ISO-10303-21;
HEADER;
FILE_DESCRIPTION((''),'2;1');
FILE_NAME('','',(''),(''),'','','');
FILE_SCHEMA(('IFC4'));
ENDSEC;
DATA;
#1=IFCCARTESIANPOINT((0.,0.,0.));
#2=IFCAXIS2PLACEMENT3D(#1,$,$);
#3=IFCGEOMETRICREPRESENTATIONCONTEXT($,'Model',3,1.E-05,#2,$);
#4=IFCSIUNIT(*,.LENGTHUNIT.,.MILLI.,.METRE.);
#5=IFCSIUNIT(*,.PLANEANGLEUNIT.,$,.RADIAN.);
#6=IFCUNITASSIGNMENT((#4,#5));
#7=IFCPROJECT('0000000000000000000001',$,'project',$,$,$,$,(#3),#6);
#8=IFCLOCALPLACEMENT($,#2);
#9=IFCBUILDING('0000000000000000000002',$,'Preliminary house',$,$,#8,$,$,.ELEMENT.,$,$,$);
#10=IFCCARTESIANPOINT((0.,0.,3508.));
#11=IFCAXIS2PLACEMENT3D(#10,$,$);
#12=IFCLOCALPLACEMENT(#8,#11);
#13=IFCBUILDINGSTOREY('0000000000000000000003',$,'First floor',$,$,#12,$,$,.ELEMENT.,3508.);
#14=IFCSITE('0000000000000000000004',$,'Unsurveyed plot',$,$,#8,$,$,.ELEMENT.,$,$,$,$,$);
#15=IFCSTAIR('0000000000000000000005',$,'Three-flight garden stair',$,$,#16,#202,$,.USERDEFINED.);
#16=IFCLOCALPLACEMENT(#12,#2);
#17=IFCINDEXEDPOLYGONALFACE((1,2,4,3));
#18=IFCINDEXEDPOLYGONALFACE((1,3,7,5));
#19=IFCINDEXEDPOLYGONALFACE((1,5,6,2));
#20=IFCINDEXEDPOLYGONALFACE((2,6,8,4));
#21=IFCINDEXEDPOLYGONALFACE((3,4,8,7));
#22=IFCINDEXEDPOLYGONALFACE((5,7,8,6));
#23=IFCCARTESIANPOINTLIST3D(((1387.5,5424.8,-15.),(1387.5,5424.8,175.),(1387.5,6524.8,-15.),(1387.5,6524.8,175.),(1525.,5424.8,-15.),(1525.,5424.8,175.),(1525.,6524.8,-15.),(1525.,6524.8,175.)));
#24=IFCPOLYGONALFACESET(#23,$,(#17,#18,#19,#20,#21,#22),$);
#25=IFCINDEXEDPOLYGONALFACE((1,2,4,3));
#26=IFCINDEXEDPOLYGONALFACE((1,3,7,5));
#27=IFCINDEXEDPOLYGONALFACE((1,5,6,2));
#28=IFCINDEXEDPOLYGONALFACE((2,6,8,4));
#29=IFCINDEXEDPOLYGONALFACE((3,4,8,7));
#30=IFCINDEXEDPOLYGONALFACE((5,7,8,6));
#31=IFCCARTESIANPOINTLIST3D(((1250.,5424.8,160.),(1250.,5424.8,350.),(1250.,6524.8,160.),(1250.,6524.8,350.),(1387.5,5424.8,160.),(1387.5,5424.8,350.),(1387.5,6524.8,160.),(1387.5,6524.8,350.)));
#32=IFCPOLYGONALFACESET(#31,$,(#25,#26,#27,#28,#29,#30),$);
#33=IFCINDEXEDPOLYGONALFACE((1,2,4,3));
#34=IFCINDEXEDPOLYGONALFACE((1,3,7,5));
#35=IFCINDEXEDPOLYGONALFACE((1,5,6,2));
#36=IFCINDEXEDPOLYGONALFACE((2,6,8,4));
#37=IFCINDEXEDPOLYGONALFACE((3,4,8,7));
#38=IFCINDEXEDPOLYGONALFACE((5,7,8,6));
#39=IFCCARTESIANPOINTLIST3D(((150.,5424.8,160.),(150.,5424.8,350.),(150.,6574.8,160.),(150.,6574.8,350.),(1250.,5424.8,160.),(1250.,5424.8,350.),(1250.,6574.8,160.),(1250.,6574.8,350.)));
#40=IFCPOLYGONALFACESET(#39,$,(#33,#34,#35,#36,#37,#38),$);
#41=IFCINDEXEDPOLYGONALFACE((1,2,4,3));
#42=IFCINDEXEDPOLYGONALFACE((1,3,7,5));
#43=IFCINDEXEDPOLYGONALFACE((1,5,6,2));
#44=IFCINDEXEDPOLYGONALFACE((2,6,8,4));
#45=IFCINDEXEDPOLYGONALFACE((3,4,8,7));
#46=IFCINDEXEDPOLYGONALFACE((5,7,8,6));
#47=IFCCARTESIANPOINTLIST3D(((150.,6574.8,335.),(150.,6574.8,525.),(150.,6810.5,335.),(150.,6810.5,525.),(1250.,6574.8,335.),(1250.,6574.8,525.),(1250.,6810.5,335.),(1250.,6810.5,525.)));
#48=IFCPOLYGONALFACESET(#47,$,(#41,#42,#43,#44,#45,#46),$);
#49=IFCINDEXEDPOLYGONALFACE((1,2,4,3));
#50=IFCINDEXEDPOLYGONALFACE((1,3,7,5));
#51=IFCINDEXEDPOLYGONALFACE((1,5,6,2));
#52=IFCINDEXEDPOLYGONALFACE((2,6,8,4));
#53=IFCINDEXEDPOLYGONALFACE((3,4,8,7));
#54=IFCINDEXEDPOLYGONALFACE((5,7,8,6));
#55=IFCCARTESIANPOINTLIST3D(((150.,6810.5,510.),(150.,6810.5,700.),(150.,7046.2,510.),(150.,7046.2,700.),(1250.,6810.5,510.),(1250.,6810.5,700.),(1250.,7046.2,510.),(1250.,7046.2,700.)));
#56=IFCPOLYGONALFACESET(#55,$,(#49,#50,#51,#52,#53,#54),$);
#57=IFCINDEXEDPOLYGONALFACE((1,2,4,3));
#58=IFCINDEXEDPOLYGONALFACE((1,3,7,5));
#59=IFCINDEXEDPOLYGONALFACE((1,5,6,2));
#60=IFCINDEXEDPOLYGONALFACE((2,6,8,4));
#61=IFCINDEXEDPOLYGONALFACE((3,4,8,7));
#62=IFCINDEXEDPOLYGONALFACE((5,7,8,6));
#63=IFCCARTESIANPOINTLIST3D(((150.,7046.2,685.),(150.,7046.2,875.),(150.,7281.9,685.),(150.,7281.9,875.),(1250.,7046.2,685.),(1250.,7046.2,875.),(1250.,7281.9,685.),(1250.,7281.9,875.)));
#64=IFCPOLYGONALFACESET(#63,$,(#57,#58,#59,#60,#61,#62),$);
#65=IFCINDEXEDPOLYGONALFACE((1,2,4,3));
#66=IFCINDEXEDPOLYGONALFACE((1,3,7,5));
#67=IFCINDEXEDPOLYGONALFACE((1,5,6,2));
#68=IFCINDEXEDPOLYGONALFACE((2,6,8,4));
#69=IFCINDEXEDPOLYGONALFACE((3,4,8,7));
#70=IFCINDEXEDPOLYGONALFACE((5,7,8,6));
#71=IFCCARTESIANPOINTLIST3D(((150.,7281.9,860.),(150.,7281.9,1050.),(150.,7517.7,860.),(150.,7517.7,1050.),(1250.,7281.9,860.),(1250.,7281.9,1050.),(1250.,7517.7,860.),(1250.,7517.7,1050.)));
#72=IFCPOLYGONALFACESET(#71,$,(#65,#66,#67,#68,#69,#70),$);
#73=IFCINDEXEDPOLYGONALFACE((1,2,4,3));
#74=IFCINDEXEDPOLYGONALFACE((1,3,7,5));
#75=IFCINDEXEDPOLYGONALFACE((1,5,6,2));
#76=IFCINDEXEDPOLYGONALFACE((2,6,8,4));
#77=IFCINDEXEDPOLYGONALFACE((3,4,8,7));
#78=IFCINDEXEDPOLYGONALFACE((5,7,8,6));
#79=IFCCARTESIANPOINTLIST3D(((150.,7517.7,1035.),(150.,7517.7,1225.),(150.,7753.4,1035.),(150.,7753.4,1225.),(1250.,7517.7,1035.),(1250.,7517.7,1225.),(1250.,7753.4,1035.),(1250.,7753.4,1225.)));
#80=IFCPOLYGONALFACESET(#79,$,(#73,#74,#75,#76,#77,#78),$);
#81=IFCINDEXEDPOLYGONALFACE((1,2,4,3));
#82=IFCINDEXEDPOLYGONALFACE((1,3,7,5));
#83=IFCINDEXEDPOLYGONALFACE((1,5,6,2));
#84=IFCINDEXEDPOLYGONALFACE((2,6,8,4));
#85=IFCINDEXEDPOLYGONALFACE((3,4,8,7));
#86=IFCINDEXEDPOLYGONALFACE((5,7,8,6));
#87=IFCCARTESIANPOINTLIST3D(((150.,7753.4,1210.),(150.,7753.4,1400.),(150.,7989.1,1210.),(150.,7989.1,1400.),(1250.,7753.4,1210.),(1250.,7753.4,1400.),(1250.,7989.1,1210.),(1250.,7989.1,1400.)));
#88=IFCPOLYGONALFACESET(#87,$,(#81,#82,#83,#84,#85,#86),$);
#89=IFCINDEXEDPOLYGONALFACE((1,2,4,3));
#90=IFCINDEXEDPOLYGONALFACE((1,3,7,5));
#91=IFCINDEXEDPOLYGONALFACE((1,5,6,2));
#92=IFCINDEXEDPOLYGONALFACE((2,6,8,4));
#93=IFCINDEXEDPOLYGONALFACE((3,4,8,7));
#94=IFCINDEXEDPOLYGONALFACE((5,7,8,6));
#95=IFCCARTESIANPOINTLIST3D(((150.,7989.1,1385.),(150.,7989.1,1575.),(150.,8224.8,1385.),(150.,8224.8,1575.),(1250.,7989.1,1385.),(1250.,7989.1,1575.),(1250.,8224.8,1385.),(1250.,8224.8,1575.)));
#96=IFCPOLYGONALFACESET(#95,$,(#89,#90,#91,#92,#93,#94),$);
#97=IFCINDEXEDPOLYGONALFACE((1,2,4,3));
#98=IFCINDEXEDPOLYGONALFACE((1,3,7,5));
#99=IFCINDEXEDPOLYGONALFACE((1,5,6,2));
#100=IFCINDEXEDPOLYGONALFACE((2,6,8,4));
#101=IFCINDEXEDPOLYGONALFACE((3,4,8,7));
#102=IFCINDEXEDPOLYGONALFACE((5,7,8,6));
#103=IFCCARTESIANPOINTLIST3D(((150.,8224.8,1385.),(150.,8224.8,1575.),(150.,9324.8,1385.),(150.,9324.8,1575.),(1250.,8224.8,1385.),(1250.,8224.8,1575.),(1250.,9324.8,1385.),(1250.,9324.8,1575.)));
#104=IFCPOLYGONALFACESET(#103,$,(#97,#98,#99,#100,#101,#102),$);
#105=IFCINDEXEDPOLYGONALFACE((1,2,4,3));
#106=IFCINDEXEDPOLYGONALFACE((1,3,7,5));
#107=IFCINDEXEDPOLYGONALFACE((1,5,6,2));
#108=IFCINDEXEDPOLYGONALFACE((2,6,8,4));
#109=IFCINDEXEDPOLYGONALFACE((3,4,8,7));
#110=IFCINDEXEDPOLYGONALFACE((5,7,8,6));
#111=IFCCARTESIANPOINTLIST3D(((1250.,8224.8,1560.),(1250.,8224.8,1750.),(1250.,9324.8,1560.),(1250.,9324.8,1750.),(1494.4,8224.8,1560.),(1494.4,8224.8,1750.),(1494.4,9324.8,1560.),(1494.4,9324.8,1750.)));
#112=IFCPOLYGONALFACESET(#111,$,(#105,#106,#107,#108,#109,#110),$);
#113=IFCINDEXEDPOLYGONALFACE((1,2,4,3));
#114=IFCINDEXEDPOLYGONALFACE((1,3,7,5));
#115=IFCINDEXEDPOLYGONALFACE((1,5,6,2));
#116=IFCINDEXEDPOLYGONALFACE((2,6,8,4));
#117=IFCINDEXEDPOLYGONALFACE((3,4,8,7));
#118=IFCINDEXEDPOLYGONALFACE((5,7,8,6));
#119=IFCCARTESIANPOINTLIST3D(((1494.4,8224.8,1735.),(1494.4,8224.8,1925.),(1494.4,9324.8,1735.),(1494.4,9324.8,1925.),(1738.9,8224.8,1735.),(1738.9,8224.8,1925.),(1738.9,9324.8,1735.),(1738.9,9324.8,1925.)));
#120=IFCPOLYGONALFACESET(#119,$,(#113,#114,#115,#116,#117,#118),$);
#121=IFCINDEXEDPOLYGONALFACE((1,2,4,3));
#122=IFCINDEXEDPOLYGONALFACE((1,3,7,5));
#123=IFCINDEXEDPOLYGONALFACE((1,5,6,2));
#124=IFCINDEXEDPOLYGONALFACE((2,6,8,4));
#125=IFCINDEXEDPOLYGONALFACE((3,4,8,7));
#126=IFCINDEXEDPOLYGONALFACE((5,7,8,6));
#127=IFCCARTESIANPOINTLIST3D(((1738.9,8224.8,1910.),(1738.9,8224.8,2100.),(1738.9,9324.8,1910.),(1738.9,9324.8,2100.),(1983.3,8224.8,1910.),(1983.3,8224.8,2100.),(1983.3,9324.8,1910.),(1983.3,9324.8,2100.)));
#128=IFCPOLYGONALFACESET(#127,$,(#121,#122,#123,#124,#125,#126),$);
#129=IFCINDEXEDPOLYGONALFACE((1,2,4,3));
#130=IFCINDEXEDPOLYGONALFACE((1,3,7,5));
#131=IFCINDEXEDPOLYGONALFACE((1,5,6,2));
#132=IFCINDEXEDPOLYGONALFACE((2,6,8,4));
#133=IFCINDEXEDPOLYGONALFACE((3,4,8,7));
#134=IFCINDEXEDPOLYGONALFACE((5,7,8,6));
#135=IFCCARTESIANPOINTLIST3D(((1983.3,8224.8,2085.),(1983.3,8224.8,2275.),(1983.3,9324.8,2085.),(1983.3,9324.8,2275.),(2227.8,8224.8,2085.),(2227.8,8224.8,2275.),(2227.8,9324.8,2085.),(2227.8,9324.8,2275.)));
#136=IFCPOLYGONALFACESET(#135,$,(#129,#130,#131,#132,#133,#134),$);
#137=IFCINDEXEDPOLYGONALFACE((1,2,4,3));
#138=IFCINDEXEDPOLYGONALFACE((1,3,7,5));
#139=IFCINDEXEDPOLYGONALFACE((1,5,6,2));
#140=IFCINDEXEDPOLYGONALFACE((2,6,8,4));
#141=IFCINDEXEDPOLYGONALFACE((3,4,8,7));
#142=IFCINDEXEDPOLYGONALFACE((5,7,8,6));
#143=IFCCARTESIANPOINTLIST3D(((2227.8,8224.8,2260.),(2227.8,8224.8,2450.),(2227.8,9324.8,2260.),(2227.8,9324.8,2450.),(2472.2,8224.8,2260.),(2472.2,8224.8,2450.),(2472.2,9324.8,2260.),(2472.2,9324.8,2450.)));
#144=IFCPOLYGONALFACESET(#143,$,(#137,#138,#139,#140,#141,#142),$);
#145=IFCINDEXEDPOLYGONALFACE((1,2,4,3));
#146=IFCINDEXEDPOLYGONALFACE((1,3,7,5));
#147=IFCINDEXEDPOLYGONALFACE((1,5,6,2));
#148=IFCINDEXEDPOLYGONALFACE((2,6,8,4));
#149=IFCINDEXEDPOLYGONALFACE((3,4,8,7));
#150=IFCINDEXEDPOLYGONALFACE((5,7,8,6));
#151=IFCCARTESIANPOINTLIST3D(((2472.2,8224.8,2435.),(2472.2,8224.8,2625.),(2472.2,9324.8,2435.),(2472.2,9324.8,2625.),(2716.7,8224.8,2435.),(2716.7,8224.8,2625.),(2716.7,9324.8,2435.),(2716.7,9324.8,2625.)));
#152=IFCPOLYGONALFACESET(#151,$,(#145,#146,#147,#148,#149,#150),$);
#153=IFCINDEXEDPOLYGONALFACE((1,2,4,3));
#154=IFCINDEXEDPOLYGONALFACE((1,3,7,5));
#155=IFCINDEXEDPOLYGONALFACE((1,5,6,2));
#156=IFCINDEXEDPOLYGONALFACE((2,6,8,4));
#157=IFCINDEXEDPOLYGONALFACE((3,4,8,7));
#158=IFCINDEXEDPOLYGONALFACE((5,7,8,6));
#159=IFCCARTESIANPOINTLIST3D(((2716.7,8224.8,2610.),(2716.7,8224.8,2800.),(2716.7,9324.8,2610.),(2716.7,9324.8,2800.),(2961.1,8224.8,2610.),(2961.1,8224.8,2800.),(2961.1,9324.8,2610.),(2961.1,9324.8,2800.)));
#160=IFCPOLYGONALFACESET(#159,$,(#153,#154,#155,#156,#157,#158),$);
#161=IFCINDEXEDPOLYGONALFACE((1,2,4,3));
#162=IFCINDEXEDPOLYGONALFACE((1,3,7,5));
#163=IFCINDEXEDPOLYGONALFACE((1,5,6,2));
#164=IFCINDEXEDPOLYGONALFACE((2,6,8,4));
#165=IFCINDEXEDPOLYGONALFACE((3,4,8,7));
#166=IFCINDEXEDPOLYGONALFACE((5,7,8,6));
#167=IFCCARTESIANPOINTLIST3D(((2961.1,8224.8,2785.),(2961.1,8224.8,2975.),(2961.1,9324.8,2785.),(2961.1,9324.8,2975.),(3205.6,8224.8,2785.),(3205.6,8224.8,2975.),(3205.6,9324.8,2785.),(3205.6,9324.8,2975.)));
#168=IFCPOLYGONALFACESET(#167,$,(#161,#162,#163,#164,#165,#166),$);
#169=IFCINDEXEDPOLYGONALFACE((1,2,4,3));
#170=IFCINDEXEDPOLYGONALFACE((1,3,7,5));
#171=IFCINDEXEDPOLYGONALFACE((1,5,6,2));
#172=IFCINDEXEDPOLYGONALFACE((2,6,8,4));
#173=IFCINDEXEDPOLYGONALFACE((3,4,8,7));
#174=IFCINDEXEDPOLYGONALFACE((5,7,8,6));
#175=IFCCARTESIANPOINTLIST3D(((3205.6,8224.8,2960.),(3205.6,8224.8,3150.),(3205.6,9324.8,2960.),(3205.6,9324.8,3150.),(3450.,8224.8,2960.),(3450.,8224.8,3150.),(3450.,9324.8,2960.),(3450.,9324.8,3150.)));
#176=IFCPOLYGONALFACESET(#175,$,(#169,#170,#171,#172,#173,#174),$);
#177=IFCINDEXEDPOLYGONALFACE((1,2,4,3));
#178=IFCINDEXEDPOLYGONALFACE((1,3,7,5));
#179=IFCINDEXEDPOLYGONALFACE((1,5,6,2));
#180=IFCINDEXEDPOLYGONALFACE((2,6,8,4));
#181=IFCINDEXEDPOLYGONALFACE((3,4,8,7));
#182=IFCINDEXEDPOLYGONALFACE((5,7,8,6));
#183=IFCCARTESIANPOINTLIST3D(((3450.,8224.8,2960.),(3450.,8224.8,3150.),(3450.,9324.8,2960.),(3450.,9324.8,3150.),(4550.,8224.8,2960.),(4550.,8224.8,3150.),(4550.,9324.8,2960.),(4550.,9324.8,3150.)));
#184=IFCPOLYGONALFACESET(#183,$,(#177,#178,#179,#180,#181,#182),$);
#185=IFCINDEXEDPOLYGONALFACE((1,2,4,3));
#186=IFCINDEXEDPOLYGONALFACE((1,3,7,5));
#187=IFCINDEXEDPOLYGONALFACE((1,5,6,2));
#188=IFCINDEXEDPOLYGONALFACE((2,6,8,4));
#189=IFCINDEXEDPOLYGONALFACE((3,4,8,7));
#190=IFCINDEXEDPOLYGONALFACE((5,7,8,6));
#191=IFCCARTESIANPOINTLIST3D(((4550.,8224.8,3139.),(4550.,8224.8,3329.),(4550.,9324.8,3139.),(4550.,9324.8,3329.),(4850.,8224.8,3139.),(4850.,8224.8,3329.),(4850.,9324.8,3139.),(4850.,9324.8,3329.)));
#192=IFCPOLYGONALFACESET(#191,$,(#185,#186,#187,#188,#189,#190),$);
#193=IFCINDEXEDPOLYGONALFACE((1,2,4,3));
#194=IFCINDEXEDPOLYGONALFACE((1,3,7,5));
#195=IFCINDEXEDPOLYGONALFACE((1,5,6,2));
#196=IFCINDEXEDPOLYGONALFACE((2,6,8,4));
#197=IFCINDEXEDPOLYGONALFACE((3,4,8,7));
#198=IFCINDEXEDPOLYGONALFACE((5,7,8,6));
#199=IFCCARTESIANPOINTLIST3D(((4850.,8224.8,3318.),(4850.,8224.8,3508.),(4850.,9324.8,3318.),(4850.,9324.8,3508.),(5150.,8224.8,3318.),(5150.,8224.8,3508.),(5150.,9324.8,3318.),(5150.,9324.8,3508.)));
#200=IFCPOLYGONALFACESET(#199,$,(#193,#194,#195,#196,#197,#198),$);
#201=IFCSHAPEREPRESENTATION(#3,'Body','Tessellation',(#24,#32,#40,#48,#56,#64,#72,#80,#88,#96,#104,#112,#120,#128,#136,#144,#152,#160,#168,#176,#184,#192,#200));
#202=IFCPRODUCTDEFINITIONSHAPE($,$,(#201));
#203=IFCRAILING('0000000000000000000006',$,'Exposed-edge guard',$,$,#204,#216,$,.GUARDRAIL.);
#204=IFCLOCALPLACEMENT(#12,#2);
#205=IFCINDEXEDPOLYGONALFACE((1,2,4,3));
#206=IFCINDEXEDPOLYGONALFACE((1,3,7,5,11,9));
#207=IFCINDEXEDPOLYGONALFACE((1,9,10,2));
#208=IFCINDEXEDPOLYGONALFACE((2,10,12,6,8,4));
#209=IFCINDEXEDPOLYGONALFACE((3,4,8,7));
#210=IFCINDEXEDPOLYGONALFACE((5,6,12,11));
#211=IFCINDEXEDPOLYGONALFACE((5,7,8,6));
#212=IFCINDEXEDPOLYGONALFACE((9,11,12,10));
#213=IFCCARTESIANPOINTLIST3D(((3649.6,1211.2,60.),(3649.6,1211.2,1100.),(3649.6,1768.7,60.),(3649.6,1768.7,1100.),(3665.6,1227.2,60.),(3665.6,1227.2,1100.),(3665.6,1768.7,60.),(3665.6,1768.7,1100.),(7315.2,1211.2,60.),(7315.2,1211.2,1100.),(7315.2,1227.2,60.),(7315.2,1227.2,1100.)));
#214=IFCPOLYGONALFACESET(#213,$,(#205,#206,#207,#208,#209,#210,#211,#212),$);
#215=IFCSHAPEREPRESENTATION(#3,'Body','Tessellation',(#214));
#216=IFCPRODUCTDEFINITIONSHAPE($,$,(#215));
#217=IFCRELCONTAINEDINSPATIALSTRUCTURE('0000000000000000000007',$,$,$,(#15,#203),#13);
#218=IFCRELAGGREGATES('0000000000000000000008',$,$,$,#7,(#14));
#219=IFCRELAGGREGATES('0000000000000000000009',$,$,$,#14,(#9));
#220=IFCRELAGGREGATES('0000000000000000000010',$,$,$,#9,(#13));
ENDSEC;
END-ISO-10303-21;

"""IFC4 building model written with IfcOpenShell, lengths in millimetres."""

from ifc_helpers import new_model, si_unit, frame, origin, place, context, project, spatial, polyline, outline, extrude, element, save


model = new_model("IFC4")

# Units and contexts
model_context = context("Model", 3, precision=1e-05, world=origin())
ifc_project = project(units=[si_unit("LENGTHUNIT", "METRE", prefix="MILLI"), si_unit("PLANEANGLEUNIT", "RADIAN")], contexts=[model_context])

# Site, building, storey
placement_1 = place(None, origin())
site = spatial("IfcSite", under=ifc_project, at=placement_1, Name="Unsurveyed plot", CompositionType="ELEMENT")
building = spatial("IfcBuilding", under=site, at=placement_1, Name="Preliminary house", CompositionType="ELEMENT")
placement_2 = place(placement_1, frame((0.0, 0.0, 3508.0)))
storey = spatial("IfcBuildingStorey", under=building, at=placement_2, Name="First floor", CompositionType="ELEMENT", Elevation=3508.0)

# Stair
element("IfcStair", 1, at=placement_2, inside=storey, Name="Three-flight garden stair", PredefinedType="USERDEFINED", context=model_context, shape_type="SweptSolid", body=[
    extrude(outline(polyline([(1525.0, 5424.8), (1525.0, 6524.8), (1387.5, 6524.8), (1387.5, 5424.8), (1525.0, 5424.8)])), frame((0.0, 0.0, -15.0)), (0.0, 0.0, 1.0), 190.0),
    extrude(outline(polyline([(1387.5, 5424.8), (1387.5, 6524.8), (1250.0, 6524.8), (1250.0, 5424.8), (1387.5, 5424.8)])), frame((0.0, 0.0, 160.0)), (0.0, 0.0, 1.0), 190.0),
    extrude(outline(polyline([(1250.0, 5424.8), (1250.0, 6574.8), (150.0, 6574.8), (150.0, 5424.8), (1250.0, 5424.8)])), frame((0.0, 0.0, 160.0)), (0.0, 0.0, 1.0), 190.0),
    extrude(outline(polyline([(1250.0, 6574.8), (1250.0, 6810.5), (150.0, 6810.5), (150.0, 6574.8), (1250.0, 6574.8)])), frame((0.0, 0.0, 335.0)), (0.0, 0.0, 1.0), 190.0),
    extrude(outline(polyline([(1250.0, 6810.5), (1250.0, 7046.2), (150.0, 7046.2), (150.0, 6810.5), (1250.0, 6810.5)])), frame((0.0, 0.0, 510.0)), (0.0, 0.0, 1.0), 190.0),
    extrude(outline(polyline([(1250.0, 7046.2), (1250.0, 7281.9), (150.0, 7281.9), (150.0, 7046.2), (1250.0, 7046.2)])), frame((0.0, 0.0, 685.0)), (0.0, 0.0, 1.0), 190.0),
    extrude(outline(polyline([(1250.0, 7281.9), (1250.0, 7517.7), (150.0, 7517.7), (150.0, 7281.9), (1250.0, 7281.9)])), frame((0.0, 0.0, 860.0)), (0.0, 0.0, 1.0), 190.0),
    extrude(outline(polyline([(1250.0, 7517.7), (1250.0, 7753.4), (150.0, 7753.4), (150.0, 7517.7), (1250.0, 7517.7)])), frame((0.0, 0.0, 1035.0)), (0.0, 0.0, 1.0), 190.0),
    extrude(outline(polyline([(1250.0, 7753.4), (1250.0, 7989.1), (150.0, 7989.1), (150.0, 7753.4), (1250.0, 7753.4)])), frame((0.0, 0.0, 1210.0)), (0.0, 0.0, 1.0), 190.0),
    extrude(outline(polyline([(1250.0, 7989.1), (1250.0, 8224.8), (150.0, 8224.8), (150.0, 7989.1), (1250.0, 7989.1)])), frame((0.0, 0.0, 1385.0)), (0.0, 0.0, 1.0), 190.0),
    extrude(outline(polyline([(1250.0, 8224.8), (1250.0, 9324.8), (150.0, 9324.8), (150.0, 8224.8), (1250.0, 8224.8)])), frame((0.0, 0.0, 1385.0)), (0.0, 0.0, 1.0), 190.0),
    extrude(outline(polyline([(1494.4, 8224.8), (1494.4, 9324.8), (1250.0, 9324.8), (1250.0, 8224.8), (1494.4, 8224.8)])), frame((0.0, 0.0, 1560.0)), (0.0, 0.0, 1.0), 190.0),
    extrude(outline(polyline([(1738.9, 8224.8), (1738.9, 9324.8), (1494.4, 9324.8), (1494.4, 8224.8), (1738.9, 8224.8)])), frame((0.0, 0.0, 1735.0)), (0.0, 0.0, 1.0), 190.0),
    extrude(outline(polyline([(1983.3, 8224.8), (1983.3, 9324.8), (1738.9, 9324.8), (1738.9, 8224.8), (1983.3, 8224.8)])), frame((0.0, 0.0, 1910.0)), (0.0, 0.0, 1.0), 190.0),
    extrude(outline(polyline([(2227.8, 8224.8), (2227.8, 9324.8), (1983.3, 9324.8), (1983.3, 8224.8), (2227.8, 8224.8)])), frame((0.0, 0.0, 2085.0)), (0.0, 0.0, 1.0), 190.0),
    extrude(outline(polyline([(2472.2, 8224.8), (2472.2, 9324.8), (2227.8, 9324.8), (2227.8, 8224.8), (2472.2, 8224.8)])), frame((0.0, 0.0, 2260.0)), (0.0, 0.0, 1.0), 190.0),
    extrude(outline(polyline([(2716.7, 8224.8), (2716.7, 9324.8), (2472.2, 9324.8), (2472.2, 8224.8), (2716.7, 8224.8)])), frame((0.0, 0.0, 2435.0)), (0.0, 0.0, 1.0), 190.0),
    extrude(outline(polyline([(2961.1, 8224.8), (2961.1, 9324.8), (2716.7, 9324.8), (2716.7, 8224.8), (2961.1, 8224.8)])), frame((0.0, 0.0, 2610.0)), (0.0, 0.0, 1.0), 190.0),
    extrude(outline(polyline([(3205.6, 8224.8), (3205.6, 9324.8), (2961.1, 9324.8), (2961.1, 8224.8), (3205.6, 8224.8)])), frame((0.0, 0.0, 2785.0)), (0.0, 0.0, 1.0), 190.0),
    extrude(outline(polyline([(3450.0, 8224.8), (3450.0, 9324.8), (3205.6, 9324.8), (3205.6, 8224.8), (3450.0, 8224.8)])), frame((0.0, 0.0, 2960.0)), (0.0, 0.0, 1.0), 190.0),
    extrude(outline(polyline([(4550.0, 8224.8), (4550.0, 9324.8), (3450.0, 9324.8), (3450.0, 8224.8), (4550.0, 8224.8)])), frame((0.0, 0.0, 2960.0)), (0.0, 0.0, 1.0), 190.0),
    extrude(outline(polyline([(4850.0, 8224.8), (4850.0, 9324.8), (4550.0, 9324.8), (4550.0, 8224.8), (4850.0, 8224.8)])), frame((0.0, 0.0, 3139.0)), (0.0, 0.0, 1.0), 190.0),
    extrude(outline(polyline([(5150.0, 8224.8), (5150.0, 9324.8), (4850.0, 9324.8), (4850.0, 8224.8), (5150.0, 8224.8)])), frame((0.0, 0.0, 3318.0)), (0.0, 0.0, 1.0), 190.0),
])

# Railing
element("IfcRailing", 2, at=placement_2, inside=storey, Name="Exposed-edge guard", PredefinedType="GUARDRAIL", context=model_context, shape_type="SweptSolid", body=[
    extrude(outline(polyline([(3649.6, 1211.2), (3649.6, 1768.7), (3665.6, 1768.7), (3665.6, 1227.2), (7315.2, 1227.2), (7315.2, 1211.2), (3649.6, 1211.2)])), frame((0.0, 0.0, 60.0)), (0.0, 0.0, 1.0), 1040.0),
])

save(model, "model.ifc")
